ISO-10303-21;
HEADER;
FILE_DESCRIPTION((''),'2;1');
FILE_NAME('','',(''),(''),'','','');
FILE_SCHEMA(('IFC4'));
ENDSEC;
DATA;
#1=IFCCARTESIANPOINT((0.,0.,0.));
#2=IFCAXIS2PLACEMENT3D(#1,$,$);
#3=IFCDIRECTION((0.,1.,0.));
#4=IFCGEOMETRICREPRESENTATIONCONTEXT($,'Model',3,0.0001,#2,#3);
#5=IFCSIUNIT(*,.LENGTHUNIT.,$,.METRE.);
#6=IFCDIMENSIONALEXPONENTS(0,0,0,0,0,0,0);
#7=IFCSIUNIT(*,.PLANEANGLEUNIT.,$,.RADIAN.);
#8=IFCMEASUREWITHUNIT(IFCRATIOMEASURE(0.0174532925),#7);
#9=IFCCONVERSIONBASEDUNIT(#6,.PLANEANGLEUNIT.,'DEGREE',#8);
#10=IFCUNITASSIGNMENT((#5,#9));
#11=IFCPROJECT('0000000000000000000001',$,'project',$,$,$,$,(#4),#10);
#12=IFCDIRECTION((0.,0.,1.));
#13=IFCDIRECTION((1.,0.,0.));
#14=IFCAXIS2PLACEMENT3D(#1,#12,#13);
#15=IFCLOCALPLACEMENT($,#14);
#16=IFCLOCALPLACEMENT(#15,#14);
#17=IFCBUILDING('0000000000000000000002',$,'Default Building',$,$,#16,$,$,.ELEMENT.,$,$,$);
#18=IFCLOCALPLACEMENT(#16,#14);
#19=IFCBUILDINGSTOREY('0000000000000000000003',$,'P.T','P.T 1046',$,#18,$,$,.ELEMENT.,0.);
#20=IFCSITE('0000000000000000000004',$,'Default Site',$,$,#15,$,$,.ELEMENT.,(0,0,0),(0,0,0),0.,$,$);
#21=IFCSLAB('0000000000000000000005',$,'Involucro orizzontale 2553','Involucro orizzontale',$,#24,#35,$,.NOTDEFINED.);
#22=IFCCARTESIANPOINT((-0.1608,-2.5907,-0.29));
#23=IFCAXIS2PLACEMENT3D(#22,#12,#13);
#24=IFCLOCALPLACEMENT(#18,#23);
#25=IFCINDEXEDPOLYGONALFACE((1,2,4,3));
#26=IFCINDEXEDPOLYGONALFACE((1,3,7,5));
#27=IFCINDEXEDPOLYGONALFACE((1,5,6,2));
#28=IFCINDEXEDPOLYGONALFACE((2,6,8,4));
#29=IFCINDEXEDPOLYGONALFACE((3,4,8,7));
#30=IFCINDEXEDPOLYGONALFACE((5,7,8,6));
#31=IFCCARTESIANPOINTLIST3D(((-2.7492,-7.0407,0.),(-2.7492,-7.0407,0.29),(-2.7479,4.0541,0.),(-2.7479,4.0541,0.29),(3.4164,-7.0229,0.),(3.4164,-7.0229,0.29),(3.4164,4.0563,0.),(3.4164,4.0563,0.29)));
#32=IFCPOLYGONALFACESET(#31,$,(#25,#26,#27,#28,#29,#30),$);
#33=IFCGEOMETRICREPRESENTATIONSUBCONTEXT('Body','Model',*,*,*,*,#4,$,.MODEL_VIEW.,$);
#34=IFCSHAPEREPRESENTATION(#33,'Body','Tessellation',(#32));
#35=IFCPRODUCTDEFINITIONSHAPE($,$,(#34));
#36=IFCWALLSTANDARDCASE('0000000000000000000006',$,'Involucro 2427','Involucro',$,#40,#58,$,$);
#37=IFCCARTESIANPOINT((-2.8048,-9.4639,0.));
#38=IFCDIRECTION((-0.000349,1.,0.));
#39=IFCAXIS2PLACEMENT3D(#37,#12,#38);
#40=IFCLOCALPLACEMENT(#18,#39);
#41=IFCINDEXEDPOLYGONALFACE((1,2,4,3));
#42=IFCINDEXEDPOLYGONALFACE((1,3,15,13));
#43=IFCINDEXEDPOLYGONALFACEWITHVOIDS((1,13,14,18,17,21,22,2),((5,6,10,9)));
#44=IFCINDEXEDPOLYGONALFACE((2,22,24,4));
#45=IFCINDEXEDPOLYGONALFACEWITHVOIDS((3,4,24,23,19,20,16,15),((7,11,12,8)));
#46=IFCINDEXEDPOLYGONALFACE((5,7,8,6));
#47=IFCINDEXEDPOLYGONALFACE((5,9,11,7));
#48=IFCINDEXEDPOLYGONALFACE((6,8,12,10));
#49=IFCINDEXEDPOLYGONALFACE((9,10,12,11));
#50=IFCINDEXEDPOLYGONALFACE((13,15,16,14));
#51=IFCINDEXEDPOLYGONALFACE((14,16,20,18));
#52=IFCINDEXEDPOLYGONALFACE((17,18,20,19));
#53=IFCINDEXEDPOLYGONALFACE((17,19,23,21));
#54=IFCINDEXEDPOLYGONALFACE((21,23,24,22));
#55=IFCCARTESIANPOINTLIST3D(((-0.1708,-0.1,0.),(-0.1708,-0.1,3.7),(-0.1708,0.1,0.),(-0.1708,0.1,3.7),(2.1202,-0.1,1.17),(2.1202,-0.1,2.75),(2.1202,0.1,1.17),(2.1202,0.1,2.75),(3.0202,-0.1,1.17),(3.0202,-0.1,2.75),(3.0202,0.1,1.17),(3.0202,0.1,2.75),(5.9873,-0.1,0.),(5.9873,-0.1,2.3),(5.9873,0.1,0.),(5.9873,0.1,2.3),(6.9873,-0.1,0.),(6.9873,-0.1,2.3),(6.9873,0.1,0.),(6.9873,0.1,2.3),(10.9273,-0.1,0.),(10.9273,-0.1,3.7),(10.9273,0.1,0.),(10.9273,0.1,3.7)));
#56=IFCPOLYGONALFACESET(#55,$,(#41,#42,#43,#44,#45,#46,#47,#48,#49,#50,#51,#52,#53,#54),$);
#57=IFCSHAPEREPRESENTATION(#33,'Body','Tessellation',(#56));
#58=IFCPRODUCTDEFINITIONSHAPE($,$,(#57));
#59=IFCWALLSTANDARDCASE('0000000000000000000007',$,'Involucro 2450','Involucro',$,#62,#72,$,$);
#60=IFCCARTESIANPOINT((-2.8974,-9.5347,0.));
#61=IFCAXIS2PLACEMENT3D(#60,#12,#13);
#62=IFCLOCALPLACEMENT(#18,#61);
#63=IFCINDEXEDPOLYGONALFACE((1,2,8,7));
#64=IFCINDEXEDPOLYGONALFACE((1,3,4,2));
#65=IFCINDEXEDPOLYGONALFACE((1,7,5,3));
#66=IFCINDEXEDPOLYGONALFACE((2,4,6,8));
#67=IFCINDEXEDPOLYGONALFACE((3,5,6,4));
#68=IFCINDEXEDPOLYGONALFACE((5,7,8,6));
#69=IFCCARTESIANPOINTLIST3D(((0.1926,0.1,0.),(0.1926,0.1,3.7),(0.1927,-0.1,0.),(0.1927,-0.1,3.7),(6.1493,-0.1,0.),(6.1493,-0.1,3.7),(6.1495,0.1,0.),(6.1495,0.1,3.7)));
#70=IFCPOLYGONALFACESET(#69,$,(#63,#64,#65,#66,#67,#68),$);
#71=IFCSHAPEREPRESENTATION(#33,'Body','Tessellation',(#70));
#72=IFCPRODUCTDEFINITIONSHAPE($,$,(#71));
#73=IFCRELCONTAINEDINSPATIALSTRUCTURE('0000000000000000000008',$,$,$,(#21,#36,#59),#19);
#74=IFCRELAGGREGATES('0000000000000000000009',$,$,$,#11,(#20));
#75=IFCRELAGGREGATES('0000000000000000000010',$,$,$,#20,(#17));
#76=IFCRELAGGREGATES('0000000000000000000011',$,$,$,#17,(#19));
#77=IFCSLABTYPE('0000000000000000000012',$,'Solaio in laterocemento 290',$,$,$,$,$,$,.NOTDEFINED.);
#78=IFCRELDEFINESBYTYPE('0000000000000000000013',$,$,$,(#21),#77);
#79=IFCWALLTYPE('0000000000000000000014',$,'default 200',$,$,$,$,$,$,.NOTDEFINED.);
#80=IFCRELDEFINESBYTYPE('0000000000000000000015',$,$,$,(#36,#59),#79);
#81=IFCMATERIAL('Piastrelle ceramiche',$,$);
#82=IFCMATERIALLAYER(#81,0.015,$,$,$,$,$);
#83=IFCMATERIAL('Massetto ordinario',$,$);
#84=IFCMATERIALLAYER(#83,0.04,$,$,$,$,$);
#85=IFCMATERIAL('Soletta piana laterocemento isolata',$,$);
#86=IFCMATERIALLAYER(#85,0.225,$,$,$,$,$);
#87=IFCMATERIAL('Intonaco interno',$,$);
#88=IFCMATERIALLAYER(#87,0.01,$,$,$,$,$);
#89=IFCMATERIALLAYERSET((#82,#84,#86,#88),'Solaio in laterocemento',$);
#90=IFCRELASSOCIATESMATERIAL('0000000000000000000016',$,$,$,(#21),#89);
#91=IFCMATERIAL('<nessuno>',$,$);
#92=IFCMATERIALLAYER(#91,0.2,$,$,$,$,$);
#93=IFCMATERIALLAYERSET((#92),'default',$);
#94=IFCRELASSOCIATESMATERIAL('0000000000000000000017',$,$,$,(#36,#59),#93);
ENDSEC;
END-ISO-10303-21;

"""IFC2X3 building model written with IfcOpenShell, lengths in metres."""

from ifc_helpers import new_model, entity, si_unit, converted_unit, direction, frame, origin, origin_with_axes, place, context, subcontext, project, spatial, polyline, outline, extrude, shape, material, layer, layer_set, layer_usage, type_object, element, save


model = new_model("IFC2X3")

# Units and contexts
model_context = context("Model", 3, precision=0.0001, world=origin(), true_north=direction((0.0, 1.0, 0.0)))
body_context = subcontext(model_context, "Body", "Model", "MODEL_VIEW")
profile_context = subcontext(model_context, "Profile", "Model", "MODEL_VIEW")
footprint_context = subcontext(model_context, "FootPrint", "Model", "MODEL_VIEW")
ifc_project = project(units=[si_unit("LENGTHUNIT", "METRE"), converted_unit("PLANEANGLEUNIT", "DEGREE", entity("IfcRatioMeasure", 0.0174532925), si_unit("PLANEANGLEUNIT", "RADIAN"), dimensions=[0, 0, 0, 0, 0, 0, 0])], contexts=[model_context])

# Site, building, storey
site_placement = place(None, origin_with_axes())
site = spatial("IfcSite", under=ifc_project, at=site_placement, Name="Default Site", CompositionType="ELEMENT", RefLatitude=(0, 0, 0), RefLongitude=(0, 0, 0), RefElevation=0.0)
building_placement = place(site_placement, origin_with_axes())
building = spatial("IfcBuilding", under=site, at=building_placement, Name="Default Building", CompositionType="ELEMENT")
storey_placement = place(building_placement, frame((0.0, 0.0, 0.0), z_axis=(0.0, 0.0, 1.0), x_axis=(1.0, 0.0, 0.0)))
storey = spatial("IfcBuildingStorey", under=building, at=storey_placement, Name="P.T", Description="P.T 1046", CompositionType="ELEMENT", Elevation=0.0)

# Slab
ifc_material_1 = material(Name="Piastrelle ceramiche")
ifc_layer_1 = layer(ifc_material_1, 0.015)
ifc_material_2 = material(Name="Massetto ordinario")
ifc_layer_2 = layer(ifc_material_2, 0.04)
ifc_material_3 = material(Name="Soletta piana laterocemento isolata")
ifc_layer_3 = layer(ifc_material_3, 0.225)
ifc_material_4 = material(Name="Intonaco interno")
ifc_layer_4 = layer(ifc_material_4, 0.01)
ifc_layer_set_1 = layer_set([ifc_layer_1, ifc_layer_2, ifc_layer_3, ifc_layer_4], Name="Solaio in laterocemento")
ifc_layer_usage_1 = layer_usage(ifc_layer_set_1, "AXIS3", "POSITIVE", 0.0)
slab_type = type_object("IfcSlabType", Name="Solaio in laterocemento 290", PredefinedType="NOTDEFINED")
slab_placement = place(storey_placement, frame((-0.1608, -2.5907, -0.29), z_axis=(0.0, 0.0, 1.0), x_axis=(1.0, 0.0, 0.0)))
element("IfcSlab", 1, at=slab_placement, inside=storey, type_object=slab_type, material=ifc_layer_usage_1, Name="Involucro orizzontale 2553", Description="Involucro orizzontale", PredefinedType="NOTDEFINED", context=body_context, shape_type="SweptSolid", body=[
    extrude(outline(polyline([(-2.7479, 4.0541), (3.4164, 4.0563), (3.4164, -7.0229), (-2.7492, -7.0407), (-2.7479, 4.0541)])), origin_with_axes(), (0.0, 0.0, 1.0), 0.29),
])

# Shared definitions
ifc_material_5 = material(Name="<nessuno>")

# Wall, openings
ifc_layer_5 = layer(ifc_material_5, 0.2)
ifc_layer_set_2 = layer_set([ifc_layer_5], Name="default")
ifc_layer_usage_2 = layer_usage(ifc_layer_set_2, "AXIS2", "POSITIVE", -0.1)
wall_type_1 = type_object("IfcWallType", Name="default 200", PredefinedType="NOTDEFINED")
wall_1_placement = place(storey_placement, frame((-2.8048, -9.4639, 0.0), z_axis=(0.0, 0.0, 1.0), x_axis=(-0.000349, 1.0, 0.0)))
wall_1 = element("IfcWallStandardCase", 2, at=wall_1_placement, inside=storey, type_object=wall_type_1, material=ifc_layer_usage_2, Name="Involucro 2427", Description="Involucro", context=body_context, shape_type="SweptSolid", body=[
    extrude(outline(polyline([(10.9273, 0.1), (-0.1708, 0.1), (-0.1708, -0.1), (10.9273, -0.1), (10.9273, 0.1)])), frame((0.0, 0.0, 0.0), z_axis=(0.0, 0.0, 1.0), x_axis=(1.0, 0.0, 0.0)), (0.0, 0.0, 1.0), 3.7),
])
opening_1_placement = place(wall_1_placement, frame((2.1202, 0.0, 0.0), z_axis=(0.0, 0.0, 1.0), x_axis=(1.0, 0.0, 0.0)))
cartesian_point_1 = entity("IfcCartesianPoint", [0.9, 0.0, 2.75])
cartesian_point_2 = entity("IfcCartesianPoint", [0.9, 0.1])
element("IfcOpeningElement", 3, at=opening_1_placement, cuts=wall_1, ObjectType="Opening", shapes=[
    shape(body_context, "Body", "SweptSolid", [extrude(outline(polyline([(0.0, 2.75), (0.0, 1.17), (0.9, 1.17), (0.9, 2.75), (0.0, 2.75)])), frame((0.0, 0.1, 0.0), z_axis=(0.0, -1.0, 0.0), x_axis=(1.0, 0.0, 0.0)), (0.0, 0.0, 1.0), 0.2)]),
    shape(profile_context, "Profile", "GeometricCurveSet", [entity("IfcGeometricCurveSet", [entity("IfcPolyline", [cartesian_point_1, entity("IfcCartesianPoint", [0.9, 0.0, 1.2]), entity("IfcCartesianPoint", [0.0, 0.0, 1.2]), entity("IfcCartesianPoint", [0.0, 0.0, 2.75]), cartesian_point_1])])]),
    shape(footprint_context, "FootPrint", "GeometricCurveSet", [entity("IfcGeometricCurveSet", [entity("IfcPolyline", [cartesian_point_2, entity("IfcCartesianPoint", [0.0, 0.1]), entity("IfcCartesianPoint", [0.0, -0.1]), entity("IfcCartesianPoint", [0.9, -0.1]), cartesian_point_2])])]),
])
opening_2_placement = place(wall_1_placement, frame((5.9873, 0.0, 0.0), z_axis=(0.0, 0.0, 1.0), x_axis=(1.0, 0.0, 0.0)))
cartesian_point_3 = entity("IfcCartesianPoint", [1.0, 0.06, 2.3])
cartesian_point_4 = entity("IfcCartesianPoint", [1.0, 0.1])
element("IfcOpeningElement", 4, at=opening_2_placement, cuts=wall_1, ObjectType="Opening", shapes=[
    shape(body_context, "Body", "SweptSolid", [extrude(outline(polyline([(0.0, 2.3), (0.0, 0.0), (1.0, 0.0), (1.0, 2.3), (0.0, 2.3)])), frame((0.0, 0.1, 0.0), z_axis=(0.0, -1.0, 0.0), x_axis=(1.0, 0.0, 0.0)), (0.0, 0.0, 1.0), 0.2)]),
    shape(profile_context, "Profile", "GeometricCurveSet", [entity("IfcGeometricCurveSet", [entity("IfcPolyline", [cartesian_point_3, entity("IfcCartesianPoint", [1.0, 0.06, 0.0]), entity("IfcCartesianPoint", [0.0, 0.06, 0.0]), entity("IfcCartesianPoint", [0.0, 0.06, 2.3]), cartesian_point_3])])]),
    shape(footprint_context, "FootPrint", "GeometricCurveSet", [entity("IfcGeometricCurveSet", [entity("IfcPolyline", [cartesian_point_4, entity("IfcCartesianPoint", [0.0, 0.1]), entity("IfcCartesianPoint", [0.0, -0.1]), entity("IfcCartesianPoint", [1.0, -0.1]), cartesian_point_4])])]),
])

# Wall
ifc_layer_usage_3 = layer_usage(ifc_layer_set_2, "AXIS2", "POSITIVE", -0.1)
wall_2_placement = place(storey_placement, frame((-2.8974, -9.5347, 0.0), z_axis=(0.0, 0.0, 1.0), x_axis=(1.0, 0.0, 0.0)))
element("IfcWallStandardCase", 5, at=wall_2_placement, inside=storey, type_object=wall_type_1, material=ifc_layer_usage_3, Name="Involucro 2450", Description="Involucro", context=body_context, shape_type="SweptSolid", body=[
    extrude(outline(polyline([(6.1495, 0.1), (0.1926, 0.1), (0.1927, -0.1), (6.1493, -0.1), (6.1495, 0.1)])), origin_with_axes(), (0.0, 0.0, 1.0), 3.7),
])

save(model, "model.ifc")
